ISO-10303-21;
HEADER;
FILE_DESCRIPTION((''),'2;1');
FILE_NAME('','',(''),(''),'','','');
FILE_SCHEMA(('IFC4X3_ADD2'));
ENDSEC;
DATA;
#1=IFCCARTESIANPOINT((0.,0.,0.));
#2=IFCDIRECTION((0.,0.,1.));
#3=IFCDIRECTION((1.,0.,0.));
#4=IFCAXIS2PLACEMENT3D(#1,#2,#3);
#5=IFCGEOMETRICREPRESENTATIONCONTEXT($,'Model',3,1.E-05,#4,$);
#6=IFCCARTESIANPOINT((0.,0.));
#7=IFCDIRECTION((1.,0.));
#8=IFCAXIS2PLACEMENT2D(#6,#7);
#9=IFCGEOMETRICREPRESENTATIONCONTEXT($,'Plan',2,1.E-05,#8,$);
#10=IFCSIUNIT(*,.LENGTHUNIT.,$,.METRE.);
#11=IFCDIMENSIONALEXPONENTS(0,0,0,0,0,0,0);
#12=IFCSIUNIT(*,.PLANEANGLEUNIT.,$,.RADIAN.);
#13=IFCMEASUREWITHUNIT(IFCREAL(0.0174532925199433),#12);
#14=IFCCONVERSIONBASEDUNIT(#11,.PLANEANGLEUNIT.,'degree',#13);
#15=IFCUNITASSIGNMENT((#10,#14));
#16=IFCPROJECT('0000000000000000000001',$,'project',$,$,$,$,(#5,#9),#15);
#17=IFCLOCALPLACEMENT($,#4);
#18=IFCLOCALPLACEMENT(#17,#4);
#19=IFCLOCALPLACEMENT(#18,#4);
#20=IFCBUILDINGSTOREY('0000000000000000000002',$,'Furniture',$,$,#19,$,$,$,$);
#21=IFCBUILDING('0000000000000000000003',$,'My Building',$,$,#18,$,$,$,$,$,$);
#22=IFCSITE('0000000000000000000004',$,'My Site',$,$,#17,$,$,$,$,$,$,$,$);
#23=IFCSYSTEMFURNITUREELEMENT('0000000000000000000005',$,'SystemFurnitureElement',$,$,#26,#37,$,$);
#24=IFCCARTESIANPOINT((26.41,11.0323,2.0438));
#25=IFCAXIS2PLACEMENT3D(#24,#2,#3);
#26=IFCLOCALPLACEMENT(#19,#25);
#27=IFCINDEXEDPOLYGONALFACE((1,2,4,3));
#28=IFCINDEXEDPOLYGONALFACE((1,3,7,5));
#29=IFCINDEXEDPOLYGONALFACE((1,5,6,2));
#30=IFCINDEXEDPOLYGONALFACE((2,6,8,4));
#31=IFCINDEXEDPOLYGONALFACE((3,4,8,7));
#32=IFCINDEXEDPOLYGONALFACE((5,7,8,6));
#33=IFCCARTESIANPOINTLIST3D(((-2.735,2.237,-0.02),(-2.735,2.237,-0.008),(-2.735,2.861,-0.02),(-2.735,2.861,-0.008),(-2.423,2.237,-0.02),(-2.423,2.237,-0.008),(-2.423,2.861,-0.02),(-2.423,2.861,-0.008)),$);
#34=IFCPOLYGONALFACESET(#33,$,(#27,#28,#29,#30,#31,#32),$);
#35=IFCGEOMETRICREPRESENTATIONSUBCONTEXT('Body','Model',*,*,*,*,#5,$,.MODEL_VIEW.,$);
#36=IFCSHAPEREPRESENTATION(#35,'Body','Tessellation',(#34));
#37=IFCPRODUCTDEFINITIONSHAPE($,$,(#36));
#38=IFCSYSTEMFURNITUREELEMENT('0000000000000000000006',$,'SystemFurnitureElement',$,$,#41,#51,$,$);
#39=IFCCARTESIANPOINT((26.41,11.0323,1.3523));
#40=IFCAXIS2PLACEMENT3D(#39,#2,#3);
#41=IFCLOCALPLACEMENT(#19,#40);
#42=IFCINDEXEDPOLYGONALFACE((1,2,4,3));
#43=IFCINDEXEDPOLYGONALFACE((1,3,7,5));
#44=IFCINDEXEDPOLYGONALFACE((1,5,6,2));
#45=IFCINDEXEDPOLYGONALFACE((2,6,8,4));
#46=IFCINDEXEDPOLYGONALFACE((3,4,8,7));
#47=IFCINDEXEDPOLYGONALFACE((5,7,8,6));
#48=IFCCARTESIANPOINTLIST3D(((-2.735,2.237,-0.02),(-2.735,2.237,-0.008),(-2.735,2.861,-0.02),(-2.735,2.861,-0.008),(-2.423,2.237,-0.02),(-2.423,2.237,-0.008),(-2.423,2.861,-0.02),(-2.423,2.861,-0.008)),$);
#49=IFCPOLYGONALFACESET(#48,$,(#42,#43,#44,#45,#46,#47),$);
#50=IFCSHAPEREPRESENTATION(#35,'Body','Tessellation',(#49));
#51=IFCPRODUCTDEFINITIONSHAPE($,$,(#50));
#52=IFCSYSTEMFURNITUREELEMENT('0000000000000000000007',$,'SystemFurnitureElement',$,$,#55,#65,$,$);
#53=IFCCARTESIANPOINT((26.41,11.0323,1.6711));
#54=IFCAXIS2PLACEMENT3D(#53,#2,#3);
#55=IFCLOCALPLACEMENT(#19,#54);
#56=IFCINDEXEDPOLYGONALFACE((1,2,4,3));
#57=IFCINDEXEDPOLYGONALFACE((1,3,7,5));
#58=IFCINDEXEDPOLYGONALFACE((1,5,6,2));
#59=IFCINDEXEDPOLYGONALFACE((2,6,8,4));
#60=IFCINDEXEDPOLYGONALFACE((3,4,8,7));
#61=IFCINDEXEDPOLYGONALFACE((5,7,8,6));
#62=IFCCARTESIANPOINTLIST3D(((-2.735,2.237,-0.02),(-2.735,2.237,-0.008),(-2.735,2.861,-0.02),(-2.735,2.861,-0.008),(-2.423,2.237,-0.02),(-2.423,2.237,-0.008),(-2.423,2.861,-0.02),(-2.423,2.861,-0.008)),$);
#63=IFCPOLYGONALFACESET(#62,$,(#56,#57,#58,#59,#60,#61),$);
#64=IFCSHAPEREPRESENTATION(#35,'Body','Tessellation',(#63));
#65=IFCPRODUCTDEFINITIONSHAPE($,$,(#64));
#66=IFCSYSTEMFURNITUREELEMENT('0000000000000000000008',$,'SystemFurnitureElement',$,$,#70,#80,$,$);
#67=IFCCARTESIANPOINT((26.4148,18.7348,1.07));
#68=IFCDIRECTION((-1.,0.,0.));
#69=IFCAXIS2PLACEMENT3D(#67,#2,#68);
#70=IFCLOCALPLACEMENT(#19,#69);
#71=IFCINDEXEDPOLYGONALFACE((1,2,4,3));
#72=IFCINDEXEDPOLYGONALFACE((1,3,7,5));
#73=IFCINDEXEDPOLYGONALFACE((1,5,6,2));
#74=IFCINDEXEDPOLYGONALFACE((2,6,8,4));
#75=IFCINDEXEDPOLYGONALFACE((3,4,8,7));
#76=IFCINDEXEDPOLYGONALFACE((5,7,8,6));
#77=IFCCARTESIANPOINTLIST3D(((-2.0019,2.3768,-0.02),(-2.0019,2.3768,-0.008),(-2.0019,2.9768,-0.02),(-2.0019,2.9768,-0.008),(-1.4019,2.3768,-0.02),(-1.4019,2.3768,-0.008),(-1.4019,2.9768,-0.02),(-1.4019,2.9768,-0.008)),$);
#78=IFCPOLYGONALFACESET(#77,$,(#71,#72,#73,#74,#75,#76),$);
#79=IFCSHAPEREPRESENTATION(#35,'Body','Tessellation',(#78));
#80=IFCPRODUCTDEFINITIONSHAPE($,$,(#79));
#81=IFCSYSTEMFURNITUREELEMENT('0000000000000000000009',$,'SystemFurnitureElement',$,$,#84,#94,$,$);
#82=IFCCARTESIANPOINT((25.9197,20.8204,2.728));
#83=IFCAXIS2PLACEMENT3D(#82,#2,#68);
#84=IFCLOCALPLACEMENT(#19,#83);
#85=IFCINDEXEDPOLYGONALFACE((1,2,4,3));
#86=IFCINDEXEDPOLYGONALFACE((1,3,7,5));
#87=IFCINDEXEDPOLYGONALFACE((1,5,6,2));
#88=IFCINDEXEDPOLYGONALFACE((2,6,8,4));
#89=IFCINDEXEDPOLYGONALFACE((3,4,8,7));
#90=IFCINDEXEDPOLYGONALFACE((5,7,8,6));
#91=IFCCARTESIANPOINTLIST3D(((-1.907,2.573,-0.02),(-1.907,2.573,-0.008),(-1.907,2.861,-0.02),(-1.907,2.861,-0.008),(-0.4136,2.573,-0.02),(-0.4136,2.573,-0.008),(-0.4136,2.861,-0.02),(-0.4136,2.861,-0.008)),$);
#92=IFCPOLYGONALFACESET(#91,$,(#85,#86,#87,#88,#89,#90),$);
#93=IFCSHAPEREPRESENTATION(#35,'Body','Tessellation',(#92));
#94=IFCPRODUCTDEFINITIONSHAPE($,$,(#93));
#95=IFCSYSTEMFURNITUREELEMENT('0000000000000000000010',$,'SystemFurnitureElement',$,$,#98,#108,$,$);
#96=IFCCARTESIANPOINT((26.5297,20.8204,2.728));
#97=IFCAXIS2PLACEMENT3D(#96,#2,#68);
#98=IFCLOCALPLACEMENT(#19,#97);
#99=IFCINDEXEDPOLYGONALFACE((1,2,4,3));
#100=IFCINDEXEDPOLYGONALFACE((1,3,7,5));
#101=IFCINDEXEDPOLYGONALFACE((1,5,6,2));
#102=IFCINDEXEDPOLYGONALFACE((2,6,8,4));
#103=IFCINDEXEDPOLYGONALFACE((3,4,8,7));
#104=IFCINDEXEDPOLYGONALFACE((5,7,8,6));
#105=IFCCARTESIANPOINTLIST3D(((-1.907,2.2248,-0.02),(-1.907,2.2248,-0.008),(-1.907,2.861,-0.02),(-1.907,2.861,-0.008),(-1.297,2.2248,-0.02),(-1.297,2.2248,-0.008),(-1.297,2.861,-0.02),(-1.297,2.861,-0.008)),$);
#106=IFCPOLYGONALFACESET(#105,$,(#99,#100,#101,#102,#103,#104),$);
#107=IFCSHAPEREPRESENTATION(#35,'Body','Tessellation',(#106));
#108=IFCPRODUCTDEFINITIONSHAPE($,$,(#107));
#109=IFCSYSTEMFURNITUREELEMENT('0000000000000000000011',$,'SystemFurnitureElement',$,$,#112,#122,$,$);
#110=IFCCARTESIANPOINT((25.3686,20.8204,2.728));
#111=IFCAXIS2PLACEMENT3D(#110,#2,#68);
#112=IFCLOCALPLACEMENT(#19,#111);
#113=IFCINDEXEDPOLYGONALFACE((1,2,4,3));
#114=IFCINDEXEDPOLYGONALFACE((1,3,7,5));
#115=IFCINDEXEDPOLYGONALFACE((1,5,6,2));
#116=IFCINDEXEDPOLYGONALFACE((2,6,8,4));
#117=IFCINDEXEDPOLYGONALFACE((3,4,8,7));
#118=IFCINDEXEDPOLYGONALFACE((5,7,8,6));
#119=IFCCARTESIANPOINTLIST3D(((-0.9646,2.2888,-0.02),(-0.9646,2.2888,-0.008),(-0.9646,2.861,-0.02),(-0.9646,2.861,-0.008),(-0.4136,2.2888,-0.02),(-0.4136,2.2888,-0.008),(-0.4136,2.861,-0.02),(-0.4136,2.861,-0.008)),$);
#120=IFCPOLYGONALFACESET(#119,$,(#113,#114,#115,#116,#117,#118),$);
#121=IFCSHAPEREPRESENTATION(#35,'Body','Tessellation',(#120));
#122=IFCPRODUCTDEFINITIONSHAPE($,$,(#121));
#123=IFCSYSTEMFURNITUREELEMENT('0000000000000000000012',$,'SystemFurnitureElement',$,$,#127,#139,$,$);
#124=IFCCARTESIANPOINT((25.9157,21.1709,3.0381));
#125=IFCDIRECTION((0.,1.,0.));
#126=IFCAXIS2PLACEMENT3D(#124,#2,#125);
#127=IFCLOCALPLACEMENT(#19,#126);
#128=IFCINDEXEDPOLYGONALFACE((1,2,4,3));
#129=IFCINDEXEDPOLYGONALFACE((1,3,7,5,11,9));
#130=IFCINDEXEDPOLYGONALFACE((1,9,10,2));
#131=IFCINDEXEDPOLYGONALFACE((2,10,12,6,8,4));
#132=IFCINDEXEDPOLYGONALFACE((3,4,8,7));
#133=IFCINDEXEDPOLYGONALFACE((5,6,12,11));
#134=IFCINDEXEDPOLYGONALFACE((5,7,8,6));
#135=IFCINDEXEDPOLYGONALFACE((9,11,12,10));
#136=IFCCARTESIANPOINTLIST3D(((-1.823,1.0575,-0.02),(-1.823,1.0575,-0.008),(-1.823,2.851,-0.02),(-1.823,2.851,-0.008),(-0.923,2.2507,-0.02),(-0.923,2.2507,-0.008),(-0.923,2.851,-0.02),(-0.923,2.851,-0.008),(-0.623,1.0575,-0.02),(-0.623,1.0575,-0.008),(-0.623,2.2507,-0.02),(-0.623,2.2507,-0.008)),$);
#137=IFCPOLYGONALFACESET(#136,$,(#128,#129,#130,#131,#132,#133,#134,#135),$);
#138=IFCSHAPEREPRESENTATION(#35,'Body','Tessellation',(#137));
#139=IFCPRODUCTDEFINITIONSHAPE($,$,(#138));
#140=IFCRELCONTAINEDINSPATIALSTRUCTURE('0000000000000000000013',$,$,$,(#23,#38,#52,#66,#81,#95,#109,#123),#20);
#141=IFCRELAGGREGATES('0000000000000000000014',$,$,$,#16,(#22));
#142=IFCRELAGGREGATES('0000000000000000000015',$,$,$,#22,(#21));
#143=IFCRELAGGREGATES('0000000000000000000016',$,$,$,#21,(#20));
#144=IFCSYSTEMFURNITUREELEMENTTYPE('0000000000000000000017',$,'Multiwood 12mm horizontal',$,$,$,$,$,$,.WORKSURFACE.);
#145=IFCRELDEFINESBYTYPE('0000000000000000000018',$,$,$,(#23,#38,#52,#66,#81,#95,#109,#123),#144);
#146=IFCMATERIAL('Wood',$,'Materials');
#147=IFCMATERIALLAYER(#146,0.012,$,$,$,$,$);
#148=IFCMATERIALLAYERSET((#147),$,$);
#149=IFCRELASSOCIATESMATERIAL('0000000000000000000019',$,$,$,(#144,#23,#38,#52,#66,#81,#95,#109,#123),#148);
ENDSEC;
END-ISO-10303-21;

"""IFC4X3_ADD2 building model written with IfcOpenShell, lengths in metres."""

from ifc_helpers import new_model, entity, si_unit, converted_unit, frame, origin_with_axes, origin_2d_with_axis, place, context, subcontext, project, spatial, indexed_curve, outline, extrude, material, layer, layer_set, layer_usage, type_object, element, save


model = new_model("IFC4X3_ADD2")

# Units and contexts
model_context = context("Model", 3, precision=1e-05, world=origin_with_axes())
plan_context = context("Plan", 2, precision=1e-05, world=origin_2d_with_axis())
body_context = subcontext(model_context, "Body", "Model", "MODEL_VIEW")
ifc_project = project(units=[si_unit("LENGTHUNIT", "METRE"), converted_unit("PLANEANGLEUNIT", "degree", entity("IfcReal", 0.0174532925199433), si_unit("PLANEANGLEUNIT", "RADIAN"), dimensions=[0, 0, 0, 0, 0, 0, 0])], contexts=[model_context, plan_context])

# Site, building, storey
site_placement = place(None, origin_with_axes())
site = spatial("IfcSite", under=ifc_project, at=site_placement, Name="My Site")
building_placement = place(site_placement, origin_with_axes())
building = spatial("IfcBuilding", under=site, at=building_placement, Name="My Building")
storey_placement = place(building_placement, origin_with_axes())
storey = spatial("IfcBuildingStorey", under=building, at=storey_placement, Name="Furniture")

# System furniture elements
ifc_material_1 = material(Name="Wood", Category="Materials")
ifc_layer_1 = layer(ifc_material_1, 0.012)
ifc_layer_set_1 = layer_set([ifc_layer_1])
system_furniture_element_type_1 = type_object("IfcSystemFurnitureElementType", Name="Multiwood 12mm horizontal", PredefinedType="WORKSURFACE", material=ifc_layer_set_1)
ifc_layer_usage_1 = layer_usage(ifc_layer_set_1, "AXIS3", "POSITIVE", -0.02)
system_furniture_element_1_placement = place(storey_placement, frame((26.41, 11.0323, 2.0438), z_axis=(0.0, 0.0, 1.0), x_axis=(1.0, 0.0, 0.0)))
element("IfcSystemFurnitureElement", 1, at=system_furniture_element_1_placement, inside=storey, type_object=system_furniture_element_type_1, material=ifc_layer_usage_1, Name="SystemFurnitureElement", context=body_context, shape_type="SweptSolid", body=[
    extrude(outline(indexed_curve([(-2.423, 2.861), (-2.423, 2.237), (-2.735, 2.237), (-2.735, 2.861), (-2.423, 2.861)])), frame((0.0, 0.0, -0.02), z_axis=(0.0, 0.0, 1.0), x_axis=(1.0, 0.0, 0.0)), (0.0, 0.0, 1.0), 0.012),
])
ifc_layer_usage_2 = layer_usage(ifc_layer_set_1, "AXIS3", "POSITIVE", -0.02)
system_furniture_element_2_placement = place(storey_placement, frame((26.41, 11.0323, 1.3523), z_axis=(0.0, 0.0, 1.0), x_axis=(1.0, 0.0, 0.0)))
element("IfcSystemFurnitureElement", 2, at=system_furniture_element_2_placement, inside=storey, type_object=system_furniture_element_type_1, material=ifc_layer_usage_2, Name="SystemFurnitureElement", context=body_context, shape_type="SweptSolid", body=[
    extrude(outline(indexed_curve([(-2.423, 2.861), (-2.423, 2.237), (-2.735, 2.237), (-2.735, 2.861), (-2.423, 2.861)])), frame((0.0, 0.0, -0.02), z_axis=(0.0, 0.0, 1.0), x_axis=(1.0, 0.0, 0.0)), (0.0, 0.0, 1.0), 0.012),
])
ifc_layer_usage_3 = layer_usage(ifc_layer_set_1, "AXIS3", "POSITIVE", -0.02)
system_furniture_element_3_placement = place(storey_placement, frame((26.41, 11.0323, 1.6711), z_axis=(0.0, 0.0, 1.0), x_axis=(1.0, 0.0, 0.0)))
element("IfcSystemFurnitureElement", 3, at=system_furniture_element_3_placement, inside=storey, type_object=system_furniture_element_type_1, material=ifc_layer_usage_3, Name="SystemFurnitureElement", context=body_context, shape_type="SweptSolid", body=[
    extrude(outline(indexed_curve([(-2.423, 2.861), (-2.423, 2.237), (-2.735, 2.237), (-2.735, 2.861), (-2.423, 2.861)])), frame((0.0, 0.0, -0.02), z_axis=(0.0, 0.0, 1.0), x_axis=(1.0, 0.0, 0.0)), (0.0, 0.0, 1.0), 0.012),
])
ifc_layer_usage_4 = layer_usage(ifc_layer_set_1, "AXIS3", "POSITIVE", -0.02)
system_furniture_element_4_placement = place(storey_placement, frame((26.4148, 18.7348, 1.07), z_axis=(0.0, 0.0, 1.0), x_axis=(-1.0, 0.0, 0.0)))
element("IfcSystemFurnitureElement", 4, at=system_furniture_element_4_placement, inside=storey, type_object=system_furniture_element_type_1, material=ifc_layer_usage_4, Name="SystemFurnitureElement", context=body_context, shape_type="SweptSolid", body=[
    extrude(outline(indexed_curve([(-2.0019, 2.9768), (-2.0019, 2.3768), (-1.4019, 2.3768), (-1.4019, 2.9768), (-2.0019, 2.9768)])), frame((0.0, 0.0, -0.02), z_axis=(0.0, 0.0, 1.0), x_axis=(1.0, 0.0, 0.0)), (0.0, 0.0, 1.0), 0.012),
])
ifc_layer_usage_5 = layer_usage(ifc_layer_set_1, "AXIS3", "POSITIVE", -0.02)
system_furniture_element_5_placement = place(storey_placement, frame((25.9197, 20.8204, 2.728), z_axis=(0.0, 0.0, 1.0), x_axis=(-1.0, 0.0, 0.0)))
element("IfcSystemFurnitureElement", 5, at=system_furniture_element_5_placement, inside=storey, type_object=system_furniture_element_type_1, material=ifc_layer_usage_5, Name="SystemFurnitureElement", context=body_context, shape_type="SweptSolid", body=[
    extrude(outline(indexed_curve([(-1.907, 2.861), (-1.907, 2.573), (-0.4136, 2.573), (-0.4136, 2.861), (-1.907, 2.861)])), frame((0.0, 0.0, -0.02), z_axis=(0.0, 0.0, 1.0), x_axis=(1.0, 0.0, 0.0)), (0.0, 0.0, 1.0), 0.012),
])
ifc_layer_usage_6 = layer_usage(ifc_layer_set_1, "AXIS3", "POSITIVE", -0.02)
system_furniture_element_6_placement = place(storey_placement, frame((26.5297, 20.8204, 2.728), z_axis=(0.0, 0.0, 1.0), x_axis=(-1.0, 0.0, 0.0)))
element("IfcSystemFurnitureElement", 6, at=system_furniture_element_6_placement, inside=storey, type_object=system_furniture_element_type_1, material=ifc_layer_usage_6, Name="SystemFurnitureElement", context=body_context, shape_type="SweptSolid", body=[
    extrude(outline(indexed_curve([(-1.297, 2.861), (-1.297, 2.2248), (-1.907, 2.2248), (-1.907, 2.861), (-1.297, 2.861)])), frame((0.0, 0.0, -0.02), z_axis=(0.0, 0.0, 1.0), x_axis=(1.0, 0.0, 0.0)), (0.0, 0.0, 1.0), 0.012),
])
ifc_layer_usage_7 = layer_usage(ifc_layer_set_1, "AXIS3", "POSITIVE", -0.02)
system_furniture_element_7_placement = place(storey_placement, frame((25.3686, 20.8204, 2.728), z_axis=(0.0, 0.0, 1.0), x_axis=(-1.0, 0.0, 0.0)))
element("IfcSystemFurnitureElement", 7, at=system_furniture_element_7_placement, inside=storey, type_object=system_furniture_element_type_1, material=ifc_layer_usage_7, Name="SystemFurnitureElement", context=body_context, shape_type="SweptSolid", body=[
    extrude(outline(indexed_curve([(-0.4136, 2.861), (-0.4136, 2.2888), (-0.9646, 2.2888), (-0.9646, 2.861), (-0.4136, 2.861)])), frame((0.0, 0.0, -0.02), z_axis=(0.0, 0.0, 1.0), x_axis=(1.0, 0.0, 0.0)), (0.0, 0.0, 1.0), 0.012),
])
ifc_layer_usage_8 = layer_usage(ifc_layer_set_1, "AXIS3", "POSITIVE", -0.02)
system_furniture_element_8_placement = place(storey_placement, frame((25.9157, 21.1709, 3.0381), z_axis=(0.0, 0.0, 1.0), x_axis=(0.0, 1.0, 0.0)))
element("IfcSystemFurnitureElement", 8, at=system_furniture_element_8_placement, inside=storey, type_object=system_furniture_element_type_1, material=ifc_layer_usage_8, Name="SystemFurnitureElement", context=body_context, shape_type="SweptSolid", body=[
    extrude(outline(indexed_curve([(-0.623, 2.2507), (-0.923, 2.2507), (-0.923, 2.851), (-1.823, 2.851), (-1.823, 1.0575), (-0.623, 1.0575), (-0.623, 2.2507)])), frame((0.0, 0.0, -0.02), z_axis=(0.0, 0.0, 1.0), x_axis=(1.0, 0.0, 0.0)), (0.0, 0.0, 1.0), 0.012),
])

save(model, "model.ifc")
